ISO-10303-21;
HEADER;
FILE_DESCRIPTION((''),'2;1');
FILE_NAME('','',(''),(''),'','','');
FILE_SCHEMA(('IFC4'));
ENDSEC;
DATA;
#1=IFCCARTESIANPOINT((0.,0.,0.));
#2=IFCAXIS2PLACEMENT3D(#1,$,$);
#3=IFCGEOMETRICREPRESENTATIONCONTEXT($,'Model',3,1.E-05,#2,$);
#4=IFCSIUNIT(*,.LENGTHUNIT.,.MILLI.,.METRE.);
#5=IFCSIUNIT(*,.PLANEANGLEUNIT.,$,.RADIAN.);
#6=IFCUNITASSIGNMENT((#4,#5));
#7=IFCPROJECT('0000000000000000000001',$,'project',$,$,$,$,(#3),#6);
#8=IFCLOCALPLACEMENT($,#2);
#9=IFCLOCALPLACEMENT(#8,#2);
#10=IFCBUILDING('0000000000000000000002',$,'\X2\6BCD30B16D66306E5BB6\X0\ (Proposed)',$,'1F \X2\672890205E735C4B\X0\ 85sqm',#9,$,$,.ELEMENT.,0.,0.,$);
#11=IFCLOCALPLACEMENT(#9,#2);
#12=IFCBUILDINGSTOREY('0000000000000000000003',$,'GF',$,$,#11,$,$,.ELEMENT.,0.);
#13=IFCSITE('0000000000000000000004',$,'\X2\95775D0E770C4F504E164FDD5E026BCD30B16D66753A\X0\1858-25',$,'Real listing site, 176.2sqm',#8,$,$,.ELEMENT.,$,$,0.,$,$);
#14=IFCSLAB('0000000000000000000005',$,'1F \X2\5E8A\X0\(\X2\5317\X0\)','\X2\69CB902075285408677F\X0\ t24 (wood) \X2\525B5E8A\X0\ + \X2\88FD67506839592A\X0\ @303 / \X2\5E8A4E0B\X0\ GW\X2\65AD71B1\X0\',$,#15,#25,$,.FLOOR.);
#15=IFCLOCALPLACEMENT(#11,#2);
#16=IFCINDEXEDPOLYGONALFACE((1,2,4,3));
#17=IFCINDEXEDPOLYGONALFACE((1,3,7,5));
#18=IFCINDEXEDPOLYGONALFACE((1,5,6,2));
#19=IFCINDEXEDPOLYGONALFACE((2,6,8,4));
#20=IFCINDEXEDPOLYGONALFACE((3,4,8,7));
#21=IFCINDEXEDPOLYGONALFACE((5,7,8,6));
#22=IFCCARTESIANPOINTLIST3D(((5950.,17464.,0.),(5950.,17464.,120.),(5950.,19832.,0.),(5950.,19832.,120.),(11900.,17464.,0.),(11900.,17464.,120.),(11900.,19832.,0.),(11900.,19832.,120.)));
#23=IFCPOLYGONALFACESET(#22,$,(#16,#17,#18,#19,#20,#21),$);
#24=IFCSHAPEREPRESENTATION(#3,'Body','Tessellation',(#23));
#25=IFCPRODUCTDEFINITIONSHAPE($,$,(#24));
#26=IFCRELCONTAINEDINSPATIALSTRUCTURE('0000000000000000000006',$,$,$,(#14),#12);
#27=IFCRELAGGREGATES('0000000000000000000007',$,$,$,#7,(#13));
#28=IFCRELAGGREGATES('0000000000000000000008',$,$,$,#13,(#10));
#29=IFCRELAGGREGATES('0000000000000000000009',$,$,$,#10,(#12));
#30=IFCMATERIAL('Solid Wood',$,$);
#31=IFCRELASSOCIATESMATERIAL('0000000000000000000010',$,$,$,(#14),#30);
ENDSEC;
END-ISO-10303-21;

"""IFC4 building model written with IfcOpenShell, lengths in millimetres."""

from ifc_helpers import new_model, si_unit, frame, frame_2d, origin, place, context, project, spatial, rectangle, extrude, material, element, save


model = new_model("IFC4")

# Units and contexts
model_context = context("Model", 3, precision=1e-05, world=origin())
ifc_project = project(units=[si_unit("LENGTHUNIT", "METRE", prefix="MILLI"), si_unit("PLANEANGLEUNIT", "RADIAN")], contexts=[model_context])

# Site, building, storey
site_placement = place(None, origin())
site = spatial("IfcSite", under=ifc_project, at=site_placement, Name="長崎県佐世保市母ケ浦町1858-25", ObjectType="Real listing site, 176.2sqm", CompositionType="ELEMENT", RefElevation=0.0)
building_placement = place(site_placement, origin())
building = spatial("IfcBuilding", under=site, at=building_placement, Name="母ケ浦の家 (Proposed)", ObjectType="1F 木造平屋 85sqm", CompositionType="ELEMENT", ElevationOfRefHeight=0.0, ElevationOfTerrain=0.0)
storey_placement = place(building_placement, origin())
storey = spatial("IfcBuildingStorey", under=building, at=storey_placement, Name="GF", CompositionType="ELEMENT", Elevation=0.0)

# Slab
ifc_material_1 = material(Name="Solid Wood")
slab_1_placement = place(storey_placement, frame((2975.0, 8732.0, 0.0)))
element("IfcSlab", 1, at=slab_1_placement, inside=storey, material=ifc_material_1, Name="1F 床(北)", Description="構造用合板 t24 (wood) 剛床 + 製材根太 @303 / 床下 GW断熱", PredefinedType="FLOOR", context=model_context, shape_type="SweptSolid", body=[
    extrude(rectangle(XDim=5950.0, YDim=2368.0, at=frame_2d((2975.0, 1184.0))), frame((2975.0, 8732.0, 0.0)), (0.0, 0.0, 1.0), 120.0),
])

save(model, "model.ifc")
